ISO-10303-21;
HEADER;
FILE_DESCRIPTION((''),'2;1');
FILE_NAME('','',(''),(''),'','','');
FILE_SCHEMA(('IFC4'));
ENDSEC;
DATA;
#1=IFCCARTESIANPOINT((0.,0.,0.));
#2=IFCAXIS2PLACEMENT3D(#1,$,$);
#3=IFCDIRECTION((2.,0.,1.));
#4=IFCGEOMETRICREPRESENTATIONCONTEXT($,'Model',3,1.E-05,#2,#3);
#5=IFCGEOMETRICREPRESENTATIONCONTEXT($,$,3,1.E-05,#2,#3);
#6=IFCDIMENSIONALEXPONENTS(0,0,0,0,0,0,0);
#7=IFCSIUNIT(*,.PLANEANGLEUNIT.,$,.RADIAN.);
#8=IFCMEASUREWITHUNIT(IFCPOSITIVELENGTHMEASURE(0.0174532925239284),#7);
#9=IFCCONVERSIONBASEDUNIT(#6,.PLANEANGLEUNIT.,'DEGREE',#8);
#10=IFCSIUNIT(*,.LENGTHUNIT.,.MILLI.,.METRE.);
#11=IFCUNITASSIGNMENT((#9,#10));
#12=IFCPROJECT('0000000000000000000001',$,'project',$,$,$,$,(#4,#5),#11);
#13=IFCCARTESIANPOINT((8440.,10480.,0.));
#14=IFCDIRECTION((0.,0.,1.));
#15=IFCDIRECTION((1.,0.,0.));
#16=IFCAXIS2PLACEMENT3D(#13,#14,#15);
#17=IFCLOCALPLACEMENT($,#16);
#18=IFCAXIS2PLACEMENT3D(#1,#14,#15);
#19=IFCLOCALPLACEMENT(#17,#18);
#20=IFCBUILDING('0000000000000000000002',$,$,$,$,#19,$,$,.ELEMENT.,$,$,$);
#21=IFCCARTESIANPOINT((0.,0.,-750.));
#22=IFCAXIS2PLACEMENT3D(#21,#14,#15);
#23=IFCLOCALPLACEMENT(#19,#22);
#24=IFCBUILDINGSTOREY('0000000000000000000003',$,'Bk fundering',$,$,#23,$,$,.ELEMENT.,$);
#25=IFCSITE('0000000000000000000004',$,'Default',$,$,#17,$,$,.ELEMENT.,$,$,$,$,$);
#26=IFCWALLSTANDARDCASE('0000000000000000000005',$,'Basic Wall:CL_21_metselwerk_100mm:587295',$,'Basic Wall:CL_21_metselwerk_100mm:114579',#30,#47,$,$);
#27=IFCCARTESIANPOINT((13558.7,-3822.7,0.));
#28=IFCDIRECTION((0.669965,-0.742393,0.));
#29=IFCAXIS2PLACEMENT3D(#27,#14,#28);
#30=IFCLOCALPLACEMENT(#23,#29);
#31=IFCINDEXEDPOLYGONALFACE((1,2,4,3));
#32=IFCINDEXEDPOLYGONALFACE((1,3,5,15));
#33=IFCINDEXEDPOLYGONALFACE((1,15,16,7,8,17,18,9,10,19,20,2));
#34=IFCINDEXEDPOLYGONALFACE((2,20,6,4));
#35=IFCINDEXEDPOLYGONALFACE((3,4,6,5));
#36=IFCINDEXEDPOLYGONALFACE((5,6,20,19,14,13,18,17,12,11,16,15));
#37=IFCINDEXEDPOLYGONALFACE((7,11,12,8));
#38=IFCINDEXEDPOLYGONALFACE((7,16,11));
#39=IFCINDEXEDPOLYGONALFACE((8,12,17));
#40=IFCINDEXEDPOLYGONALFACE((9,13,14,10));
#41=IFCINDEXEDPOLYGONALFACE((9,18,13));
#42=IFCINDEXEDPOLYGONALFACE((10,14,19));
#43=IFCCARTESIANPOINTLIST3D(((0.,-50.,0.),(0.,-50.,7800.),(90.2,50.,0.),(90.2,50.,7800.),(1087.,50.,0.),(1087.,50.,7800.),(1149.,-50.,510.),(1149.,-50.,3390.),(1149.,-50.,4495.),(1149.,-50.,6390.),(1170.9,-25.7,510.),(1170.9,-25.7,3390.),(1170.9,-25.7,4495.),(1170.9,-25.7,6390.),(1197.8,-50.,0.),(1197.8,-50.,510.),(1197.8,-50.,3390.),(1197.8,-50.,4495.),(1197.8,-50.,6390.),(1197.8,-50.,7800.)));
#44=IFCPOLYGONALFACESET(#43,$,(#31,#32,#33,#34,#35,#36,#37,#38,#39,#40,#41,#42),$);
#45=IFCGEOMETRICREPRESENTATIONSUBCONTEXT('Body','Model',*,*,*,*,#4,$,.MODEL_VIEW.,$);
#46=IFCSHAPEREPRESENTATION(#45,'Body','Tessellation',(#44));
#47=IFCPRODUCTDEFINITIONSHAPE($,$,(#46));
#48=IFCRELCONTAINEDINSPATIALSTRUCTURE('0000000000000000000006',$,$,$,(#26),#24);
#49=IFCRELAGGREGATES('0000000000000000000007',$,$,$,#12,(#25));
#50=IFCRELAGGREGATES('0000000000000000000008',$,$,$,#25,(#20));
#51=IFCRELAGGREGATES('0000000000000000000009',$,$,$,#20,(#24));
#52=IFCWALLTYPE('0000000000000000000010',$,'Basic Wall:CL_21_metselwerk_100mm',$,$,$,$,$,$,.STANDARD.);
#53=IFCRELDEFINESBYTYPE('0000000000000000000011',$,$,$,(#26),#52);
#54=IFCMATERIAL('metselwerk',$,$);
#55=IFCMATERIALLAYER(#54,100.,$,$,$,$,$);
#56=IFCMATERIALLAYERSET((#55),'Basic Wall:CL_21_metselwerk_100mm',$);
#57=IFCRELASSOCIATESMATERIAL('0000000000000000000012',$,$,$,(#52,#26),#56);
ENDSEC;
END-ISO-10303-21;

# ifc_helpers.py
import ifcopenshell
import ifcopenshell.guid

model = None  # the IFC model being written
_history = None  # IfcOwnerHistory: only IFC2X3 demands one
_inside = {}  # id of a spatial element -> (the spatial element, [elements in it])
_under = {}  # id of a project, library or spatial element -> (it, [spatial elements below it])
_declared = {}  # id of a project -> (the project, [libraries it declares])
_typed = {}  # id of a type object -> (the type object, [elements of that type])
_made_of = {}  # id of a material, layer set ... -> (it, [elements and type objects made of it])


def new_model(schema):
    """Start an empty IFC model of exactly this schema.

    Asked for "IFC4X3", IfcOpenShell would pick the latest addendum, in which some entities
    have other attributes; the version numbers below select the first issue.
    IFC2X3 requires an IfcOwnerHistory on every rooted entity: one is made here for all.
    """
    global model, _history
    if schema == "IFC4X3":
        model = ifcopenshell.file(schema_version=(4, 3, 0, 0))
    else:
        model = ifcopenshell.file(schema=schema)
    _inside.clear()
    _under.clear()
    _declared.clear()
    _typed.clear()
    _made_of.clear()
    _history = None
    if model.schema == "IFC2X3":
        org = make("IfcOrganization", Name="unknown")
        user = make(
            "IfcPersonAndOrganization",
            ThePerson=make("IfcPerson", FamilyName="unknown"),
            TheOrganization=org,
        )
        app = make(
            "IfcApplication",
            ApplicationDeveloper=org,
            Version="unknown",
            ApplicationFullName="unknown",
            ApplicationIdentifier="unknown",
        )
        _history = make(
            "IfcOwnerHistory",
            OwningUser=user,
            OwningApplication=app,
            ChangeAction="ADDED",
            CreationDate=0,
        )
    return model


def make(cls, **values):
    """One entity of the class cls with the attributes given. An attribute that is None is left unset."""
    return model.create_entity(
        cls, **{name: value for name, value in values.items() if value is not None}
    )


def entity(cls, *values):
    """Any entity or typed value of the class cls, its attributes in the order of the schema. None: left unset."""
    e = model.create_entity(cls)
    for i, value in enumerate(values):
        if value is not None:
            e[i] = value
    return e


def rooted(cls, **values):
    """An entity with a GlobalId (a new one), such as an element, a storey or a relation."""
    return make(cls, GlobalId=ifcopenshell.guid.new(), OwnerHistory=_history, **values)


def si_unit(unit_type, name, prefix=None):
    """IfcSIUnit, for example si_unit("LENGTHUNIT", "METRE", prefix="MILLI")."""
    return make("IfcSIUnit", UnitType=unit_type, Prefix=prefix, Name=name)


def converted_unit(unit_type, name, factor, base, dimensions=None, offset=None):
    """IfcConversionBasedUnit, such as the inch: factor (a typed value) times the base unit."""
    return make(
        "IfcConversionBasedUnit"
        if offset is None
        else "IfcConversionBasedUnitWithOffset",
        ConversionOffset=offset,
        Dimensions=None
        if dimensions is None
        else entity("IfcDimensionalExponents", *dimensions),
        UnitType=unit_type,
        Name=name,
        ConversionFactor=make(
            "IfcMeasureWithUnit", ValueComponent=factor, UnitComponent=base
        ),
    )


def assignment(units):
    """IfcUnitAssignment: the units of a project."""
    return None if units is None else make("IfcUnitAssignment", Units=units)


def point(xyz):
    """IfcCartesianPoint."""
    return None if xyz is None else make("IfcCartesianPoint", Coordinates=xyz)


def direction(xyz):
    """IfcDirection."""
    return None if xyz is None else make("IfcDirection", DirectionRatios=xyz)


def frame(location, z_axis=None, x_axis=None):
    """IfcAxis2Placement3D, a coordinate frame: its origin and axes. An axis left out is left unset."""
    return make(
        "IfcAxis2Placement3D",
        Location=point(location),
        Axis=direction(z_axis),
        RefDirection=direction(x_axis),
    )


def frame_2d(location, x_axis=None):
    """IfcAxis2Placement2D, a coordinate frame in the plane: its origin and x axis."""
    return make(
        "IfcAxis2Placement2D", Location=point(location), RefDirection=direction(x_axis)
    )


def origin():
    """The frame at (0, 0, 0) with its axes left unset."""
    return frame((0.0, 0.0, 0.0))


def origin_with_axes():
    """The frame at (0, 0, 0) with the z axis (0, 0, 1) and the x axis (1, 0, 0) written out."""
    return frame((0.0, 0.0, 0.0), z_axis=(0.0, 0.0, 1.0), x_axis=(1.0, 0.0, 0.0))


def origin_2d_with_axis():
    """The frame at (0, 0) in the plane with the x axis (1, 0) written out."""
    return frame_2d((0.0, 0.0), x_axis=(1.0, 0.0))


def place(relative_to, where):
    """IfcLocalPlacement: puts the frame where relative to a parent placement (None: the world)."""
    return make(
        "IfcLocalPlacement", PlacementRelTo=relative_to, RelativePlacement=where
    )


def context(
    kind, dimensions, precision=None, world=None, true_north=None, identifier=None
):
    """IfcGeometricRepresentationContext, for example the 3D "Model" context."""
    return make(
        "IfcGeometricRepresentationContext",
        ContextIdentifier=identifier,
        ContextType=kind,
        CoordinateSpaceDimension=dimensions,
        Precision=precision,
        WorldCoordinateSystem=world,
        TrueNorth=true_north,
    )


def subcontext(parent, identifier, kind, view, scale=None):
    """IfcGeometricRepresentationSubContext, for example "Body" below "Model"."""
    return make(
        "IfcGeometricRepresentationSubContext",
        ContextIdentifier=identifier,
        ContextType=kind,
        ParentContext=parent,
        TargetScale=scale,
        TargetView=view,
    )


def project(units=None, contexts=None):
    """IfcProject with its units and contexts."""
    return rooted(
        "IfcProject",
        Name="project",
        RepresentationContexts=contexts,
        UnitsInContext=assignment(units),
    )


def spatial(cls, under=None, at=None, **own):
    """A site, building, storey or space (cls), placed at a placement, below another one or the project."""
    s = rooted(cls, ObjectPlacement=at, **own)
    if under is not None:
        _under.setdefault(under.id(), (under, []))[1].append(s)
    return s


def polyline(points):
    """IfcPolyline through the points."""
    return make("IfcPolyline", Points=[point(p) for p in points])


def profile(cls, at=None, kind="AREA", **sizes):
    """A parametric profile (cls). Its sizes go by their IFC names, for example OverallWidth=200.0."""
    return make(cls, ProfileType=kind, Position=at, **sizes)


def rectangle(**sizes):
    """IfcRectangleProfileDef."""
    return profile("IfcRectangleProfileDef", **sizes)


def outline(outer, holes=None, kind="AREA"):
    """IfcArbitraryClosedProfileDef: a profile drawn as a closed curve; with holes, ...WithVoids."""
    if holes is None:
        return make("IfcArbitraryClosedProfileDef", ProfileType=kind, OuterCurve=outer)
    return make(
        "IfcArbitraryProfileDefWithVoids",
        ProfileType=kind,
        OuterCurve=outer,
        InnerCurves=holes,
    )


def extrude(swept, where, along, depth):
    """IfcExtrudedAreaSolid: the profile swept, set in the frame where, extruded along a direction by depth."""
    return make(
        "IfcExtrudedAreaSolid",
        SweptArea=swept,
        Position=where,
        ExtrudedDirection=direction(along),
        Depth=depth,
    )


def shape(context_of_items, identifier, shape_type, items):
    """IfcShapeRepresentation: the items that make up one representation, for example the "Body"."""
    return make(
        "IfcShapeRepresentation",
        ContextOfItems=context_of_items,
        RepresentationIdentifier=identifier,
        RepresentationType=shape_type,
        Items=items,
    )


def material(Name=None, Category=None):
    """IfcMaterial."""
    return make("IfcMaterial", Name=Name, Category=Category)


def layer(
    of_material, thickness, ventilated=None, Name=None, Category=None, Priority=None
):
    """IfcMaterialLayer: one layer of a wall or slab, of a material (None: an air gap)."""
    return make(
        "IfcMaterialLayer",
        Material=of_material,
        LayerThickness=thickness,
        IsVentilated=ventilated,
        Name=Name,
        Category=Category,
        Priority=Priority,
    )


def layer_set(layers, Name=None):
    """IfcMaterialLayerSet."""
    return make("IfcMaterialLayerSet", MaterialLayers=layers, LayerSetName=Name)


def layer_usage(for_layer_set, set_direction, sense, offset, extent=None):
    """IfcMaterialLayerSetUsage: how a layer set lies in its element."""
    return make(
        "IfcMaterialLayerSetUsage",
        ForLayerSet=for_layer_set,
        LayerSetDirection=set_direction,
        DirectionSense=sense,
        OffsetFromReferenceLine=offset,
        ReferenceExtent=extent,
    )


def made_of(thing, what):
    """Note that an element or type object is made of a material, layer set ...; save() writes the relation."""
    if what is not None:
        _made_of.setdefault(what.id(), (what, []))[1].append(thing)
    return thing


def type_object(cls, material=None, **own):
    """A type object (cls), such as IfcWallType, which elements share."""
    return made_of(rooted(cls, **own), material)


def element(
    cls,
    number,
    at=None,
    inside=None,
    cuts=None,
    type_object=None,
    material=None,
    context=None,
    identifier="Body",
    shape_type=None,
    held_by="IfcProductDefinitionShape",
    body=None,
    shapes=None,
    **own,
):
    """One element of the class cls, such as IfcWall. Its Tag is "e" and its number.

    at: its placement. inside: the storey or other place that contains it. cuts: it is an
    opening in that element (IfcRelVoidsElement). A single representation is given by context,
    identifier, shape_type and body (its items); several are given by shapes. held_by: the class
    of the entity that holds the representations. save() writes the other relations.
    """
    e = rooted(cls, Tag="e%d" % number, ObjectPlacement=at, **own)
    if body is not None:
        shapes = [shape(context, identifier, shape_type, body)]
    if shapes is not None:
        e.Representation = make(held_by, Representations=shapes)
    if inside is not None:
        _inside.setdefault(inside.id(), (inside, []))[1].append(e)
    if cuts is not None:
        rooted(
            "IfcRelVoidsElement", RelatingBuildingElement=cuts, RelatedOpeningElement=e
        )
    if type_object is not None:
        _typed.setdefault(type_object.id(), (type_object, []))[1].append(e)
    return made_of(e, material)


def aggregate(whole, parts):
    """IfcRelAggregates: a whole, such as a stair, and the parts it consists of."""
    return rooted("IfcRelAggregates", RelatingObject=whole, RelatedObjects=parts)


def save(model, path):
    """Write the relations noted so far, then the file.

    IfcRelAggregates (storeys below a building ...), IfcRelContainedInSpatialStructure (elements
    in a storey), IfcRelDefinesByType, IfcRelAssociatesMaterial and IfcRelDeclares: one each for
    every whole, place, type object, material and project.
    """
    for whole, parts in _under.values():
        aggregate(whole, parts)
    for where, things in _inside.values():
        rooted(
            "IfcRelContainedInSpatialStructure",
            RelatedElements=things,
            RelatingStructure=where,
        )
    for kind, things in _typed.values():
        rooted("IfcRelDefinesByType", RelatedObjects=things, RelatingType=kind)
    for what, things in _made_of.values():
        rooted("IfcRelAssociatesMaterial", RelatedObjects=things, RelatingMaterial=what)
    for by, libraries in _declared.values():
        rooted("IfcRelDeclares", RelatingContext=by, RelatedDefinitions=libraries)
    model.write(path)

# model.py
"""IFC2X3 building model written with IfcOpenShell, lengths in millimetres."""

from ifc_helpers import new_model, entity, si_unit, converted_unit, direction, frame, origin, origin_with_axes, origin_2d_with_axis, place, context, subcontext, project, spatial, polyline, rectangle, outline, extrude, material, layer, layer_set, layer_usage, type_object, element, save


model = new_model("IFC2X3")

# Units and contexts
model_context = context("Model", 3, precision=1e-05, world=origin(), true_north=direction((2.0, 0.0, 1.0)))
context_of_model = context(None, 3, precision=1e-05, world=origin(), true_north=direction((2.0, 0.0, 1.0)))
body_context = subcontext(model_context, "Body", "Model", "MODEL_VIEW")
ifc_project = project(units=[converted_unit("PLANEANGLEUNIT", "DEGREE", entity("IfcPositiveLengthMeasure", 0.0174532925239284), si_unit("PLANEANGLEUNIT", "RADIAN"), dimensions=[0, 0, 0, 0, 0, 0, 0]), si_unit("LENGTHUNIT", "METRE", prefix="MILLI")], contexts=[model_context, context_of_model])

# Site, building, storey
site_placement = place(None, frame((8440.0, 10480.0, 0.0), z_axis=(0.0, 0.0, 1.0), x_axis=(1.0, 0.0, 0.0)))
site = spatial("IfcSite", under=ifc_project, at=site_placement, Name="Default", CompositionType="ELEMENT")
building_placement = place(site_placement, origin_with_axes())
building = spatial("IfcBuilding", under=site, at=building_placement, CompositionType="ELEMENT")
storey_placement = place(building_placement, frame((0.0, 0.0, -750.0), z_axis=(0.0, 0.0, 1.0), x_axis=(1.0, 0.0, 0.0)))
storey = spatial("IfcBuildingStorey", under=building, at=storey_placement, Name="Bk fundering", CompositionType="ELEMENT")

# Shared definitions
ifc_material_1 = material(Name="metselwerk")
ifc_layer_1 = layer(ifc_material_1, 100.0)
ifc_layer_set_1 = layer_set([ifc_layer_1], Name="Basic Wall:CL_21_metselwerk_100mm")
wall_type_1 = type_object("IfcWallType", Name="Basic Wall:CL_21_metselwerk_100mm", PredefinedType="STANDARD", material=ifc_layer_set_1)

# Wall, openings
ifc_layer_usage_1 = layer_usage(ifc_layer_set_1, "AXIS2", "POSITIVE", -50.0)
wall_1_placement = place(storey_placement, frame((13558.7, -3822.7, 0.0), z_axis=(0.0, 0.0, 1.0), x_axis=(0.669965, -0.742393, 0.0)))
wall_1 = element("IfcWallStandardCase", 1, at=wall_1_placement, inside=storey, type_object=wall_type_1, material=ifc_layer_usage_1, Name="Basic Wall:CL_21_metselwerk_100mm:587295", ObjectType="Basic Wall:CL_21_metselwerk_100mm:114579", context=body_context, shape_type="SweptSolid", body=[
    extrude(outline(polyline([(1197.8, -50.0), (1087.0, 50.0), (90.2, 50.0), (0.0, -50.0), (134.7, -50.0), (1048.6, -50.0), (1197.8, -50.0)])), origin(), (0.0, 0.0, 1.0), 7800.0),
])
opening_1_placement = place(wall_1_placement, origin_with_axes())
element("IfcOpeningElement", 2, at=opening_1_placement, cuts=wall_1, ObjectType="Recess", context=body_context, shape_type="SweptSolid", body=[
    extrude(rectangle(XDim=100.0, YDim=1034.0, at=origin_2d_with_axis()), frame((1521.2, -409.2, 510.0), z_axis=(0.0, 0.0, 1.0), x_axis=(-0.669965, -0.742393, 0.0)), (0.0, 0.0, 1.0), 2880.0),
])
opening_2_placement = place(wall_1_placement, origin_with_axes())
element("IfcOpeningElement", 3, at=opening_2_placement, cuts=wall_1, ObjectType="Recess", context=body_context, shape_type="SweptSolid", body=[
    extrude(rectangle(XDim=100.0, YDim=1034.0, at=origin_2d_with_axis()), frame((1521.2, -409.2, 4495.0), z_axis=(0.0, 0.0, 1.0), x_axis=(-0.669965, -0.742393, 0.0)), (0.0, 0.0, 1.0), 1895.0),
])

save(model, "model.ifc")
